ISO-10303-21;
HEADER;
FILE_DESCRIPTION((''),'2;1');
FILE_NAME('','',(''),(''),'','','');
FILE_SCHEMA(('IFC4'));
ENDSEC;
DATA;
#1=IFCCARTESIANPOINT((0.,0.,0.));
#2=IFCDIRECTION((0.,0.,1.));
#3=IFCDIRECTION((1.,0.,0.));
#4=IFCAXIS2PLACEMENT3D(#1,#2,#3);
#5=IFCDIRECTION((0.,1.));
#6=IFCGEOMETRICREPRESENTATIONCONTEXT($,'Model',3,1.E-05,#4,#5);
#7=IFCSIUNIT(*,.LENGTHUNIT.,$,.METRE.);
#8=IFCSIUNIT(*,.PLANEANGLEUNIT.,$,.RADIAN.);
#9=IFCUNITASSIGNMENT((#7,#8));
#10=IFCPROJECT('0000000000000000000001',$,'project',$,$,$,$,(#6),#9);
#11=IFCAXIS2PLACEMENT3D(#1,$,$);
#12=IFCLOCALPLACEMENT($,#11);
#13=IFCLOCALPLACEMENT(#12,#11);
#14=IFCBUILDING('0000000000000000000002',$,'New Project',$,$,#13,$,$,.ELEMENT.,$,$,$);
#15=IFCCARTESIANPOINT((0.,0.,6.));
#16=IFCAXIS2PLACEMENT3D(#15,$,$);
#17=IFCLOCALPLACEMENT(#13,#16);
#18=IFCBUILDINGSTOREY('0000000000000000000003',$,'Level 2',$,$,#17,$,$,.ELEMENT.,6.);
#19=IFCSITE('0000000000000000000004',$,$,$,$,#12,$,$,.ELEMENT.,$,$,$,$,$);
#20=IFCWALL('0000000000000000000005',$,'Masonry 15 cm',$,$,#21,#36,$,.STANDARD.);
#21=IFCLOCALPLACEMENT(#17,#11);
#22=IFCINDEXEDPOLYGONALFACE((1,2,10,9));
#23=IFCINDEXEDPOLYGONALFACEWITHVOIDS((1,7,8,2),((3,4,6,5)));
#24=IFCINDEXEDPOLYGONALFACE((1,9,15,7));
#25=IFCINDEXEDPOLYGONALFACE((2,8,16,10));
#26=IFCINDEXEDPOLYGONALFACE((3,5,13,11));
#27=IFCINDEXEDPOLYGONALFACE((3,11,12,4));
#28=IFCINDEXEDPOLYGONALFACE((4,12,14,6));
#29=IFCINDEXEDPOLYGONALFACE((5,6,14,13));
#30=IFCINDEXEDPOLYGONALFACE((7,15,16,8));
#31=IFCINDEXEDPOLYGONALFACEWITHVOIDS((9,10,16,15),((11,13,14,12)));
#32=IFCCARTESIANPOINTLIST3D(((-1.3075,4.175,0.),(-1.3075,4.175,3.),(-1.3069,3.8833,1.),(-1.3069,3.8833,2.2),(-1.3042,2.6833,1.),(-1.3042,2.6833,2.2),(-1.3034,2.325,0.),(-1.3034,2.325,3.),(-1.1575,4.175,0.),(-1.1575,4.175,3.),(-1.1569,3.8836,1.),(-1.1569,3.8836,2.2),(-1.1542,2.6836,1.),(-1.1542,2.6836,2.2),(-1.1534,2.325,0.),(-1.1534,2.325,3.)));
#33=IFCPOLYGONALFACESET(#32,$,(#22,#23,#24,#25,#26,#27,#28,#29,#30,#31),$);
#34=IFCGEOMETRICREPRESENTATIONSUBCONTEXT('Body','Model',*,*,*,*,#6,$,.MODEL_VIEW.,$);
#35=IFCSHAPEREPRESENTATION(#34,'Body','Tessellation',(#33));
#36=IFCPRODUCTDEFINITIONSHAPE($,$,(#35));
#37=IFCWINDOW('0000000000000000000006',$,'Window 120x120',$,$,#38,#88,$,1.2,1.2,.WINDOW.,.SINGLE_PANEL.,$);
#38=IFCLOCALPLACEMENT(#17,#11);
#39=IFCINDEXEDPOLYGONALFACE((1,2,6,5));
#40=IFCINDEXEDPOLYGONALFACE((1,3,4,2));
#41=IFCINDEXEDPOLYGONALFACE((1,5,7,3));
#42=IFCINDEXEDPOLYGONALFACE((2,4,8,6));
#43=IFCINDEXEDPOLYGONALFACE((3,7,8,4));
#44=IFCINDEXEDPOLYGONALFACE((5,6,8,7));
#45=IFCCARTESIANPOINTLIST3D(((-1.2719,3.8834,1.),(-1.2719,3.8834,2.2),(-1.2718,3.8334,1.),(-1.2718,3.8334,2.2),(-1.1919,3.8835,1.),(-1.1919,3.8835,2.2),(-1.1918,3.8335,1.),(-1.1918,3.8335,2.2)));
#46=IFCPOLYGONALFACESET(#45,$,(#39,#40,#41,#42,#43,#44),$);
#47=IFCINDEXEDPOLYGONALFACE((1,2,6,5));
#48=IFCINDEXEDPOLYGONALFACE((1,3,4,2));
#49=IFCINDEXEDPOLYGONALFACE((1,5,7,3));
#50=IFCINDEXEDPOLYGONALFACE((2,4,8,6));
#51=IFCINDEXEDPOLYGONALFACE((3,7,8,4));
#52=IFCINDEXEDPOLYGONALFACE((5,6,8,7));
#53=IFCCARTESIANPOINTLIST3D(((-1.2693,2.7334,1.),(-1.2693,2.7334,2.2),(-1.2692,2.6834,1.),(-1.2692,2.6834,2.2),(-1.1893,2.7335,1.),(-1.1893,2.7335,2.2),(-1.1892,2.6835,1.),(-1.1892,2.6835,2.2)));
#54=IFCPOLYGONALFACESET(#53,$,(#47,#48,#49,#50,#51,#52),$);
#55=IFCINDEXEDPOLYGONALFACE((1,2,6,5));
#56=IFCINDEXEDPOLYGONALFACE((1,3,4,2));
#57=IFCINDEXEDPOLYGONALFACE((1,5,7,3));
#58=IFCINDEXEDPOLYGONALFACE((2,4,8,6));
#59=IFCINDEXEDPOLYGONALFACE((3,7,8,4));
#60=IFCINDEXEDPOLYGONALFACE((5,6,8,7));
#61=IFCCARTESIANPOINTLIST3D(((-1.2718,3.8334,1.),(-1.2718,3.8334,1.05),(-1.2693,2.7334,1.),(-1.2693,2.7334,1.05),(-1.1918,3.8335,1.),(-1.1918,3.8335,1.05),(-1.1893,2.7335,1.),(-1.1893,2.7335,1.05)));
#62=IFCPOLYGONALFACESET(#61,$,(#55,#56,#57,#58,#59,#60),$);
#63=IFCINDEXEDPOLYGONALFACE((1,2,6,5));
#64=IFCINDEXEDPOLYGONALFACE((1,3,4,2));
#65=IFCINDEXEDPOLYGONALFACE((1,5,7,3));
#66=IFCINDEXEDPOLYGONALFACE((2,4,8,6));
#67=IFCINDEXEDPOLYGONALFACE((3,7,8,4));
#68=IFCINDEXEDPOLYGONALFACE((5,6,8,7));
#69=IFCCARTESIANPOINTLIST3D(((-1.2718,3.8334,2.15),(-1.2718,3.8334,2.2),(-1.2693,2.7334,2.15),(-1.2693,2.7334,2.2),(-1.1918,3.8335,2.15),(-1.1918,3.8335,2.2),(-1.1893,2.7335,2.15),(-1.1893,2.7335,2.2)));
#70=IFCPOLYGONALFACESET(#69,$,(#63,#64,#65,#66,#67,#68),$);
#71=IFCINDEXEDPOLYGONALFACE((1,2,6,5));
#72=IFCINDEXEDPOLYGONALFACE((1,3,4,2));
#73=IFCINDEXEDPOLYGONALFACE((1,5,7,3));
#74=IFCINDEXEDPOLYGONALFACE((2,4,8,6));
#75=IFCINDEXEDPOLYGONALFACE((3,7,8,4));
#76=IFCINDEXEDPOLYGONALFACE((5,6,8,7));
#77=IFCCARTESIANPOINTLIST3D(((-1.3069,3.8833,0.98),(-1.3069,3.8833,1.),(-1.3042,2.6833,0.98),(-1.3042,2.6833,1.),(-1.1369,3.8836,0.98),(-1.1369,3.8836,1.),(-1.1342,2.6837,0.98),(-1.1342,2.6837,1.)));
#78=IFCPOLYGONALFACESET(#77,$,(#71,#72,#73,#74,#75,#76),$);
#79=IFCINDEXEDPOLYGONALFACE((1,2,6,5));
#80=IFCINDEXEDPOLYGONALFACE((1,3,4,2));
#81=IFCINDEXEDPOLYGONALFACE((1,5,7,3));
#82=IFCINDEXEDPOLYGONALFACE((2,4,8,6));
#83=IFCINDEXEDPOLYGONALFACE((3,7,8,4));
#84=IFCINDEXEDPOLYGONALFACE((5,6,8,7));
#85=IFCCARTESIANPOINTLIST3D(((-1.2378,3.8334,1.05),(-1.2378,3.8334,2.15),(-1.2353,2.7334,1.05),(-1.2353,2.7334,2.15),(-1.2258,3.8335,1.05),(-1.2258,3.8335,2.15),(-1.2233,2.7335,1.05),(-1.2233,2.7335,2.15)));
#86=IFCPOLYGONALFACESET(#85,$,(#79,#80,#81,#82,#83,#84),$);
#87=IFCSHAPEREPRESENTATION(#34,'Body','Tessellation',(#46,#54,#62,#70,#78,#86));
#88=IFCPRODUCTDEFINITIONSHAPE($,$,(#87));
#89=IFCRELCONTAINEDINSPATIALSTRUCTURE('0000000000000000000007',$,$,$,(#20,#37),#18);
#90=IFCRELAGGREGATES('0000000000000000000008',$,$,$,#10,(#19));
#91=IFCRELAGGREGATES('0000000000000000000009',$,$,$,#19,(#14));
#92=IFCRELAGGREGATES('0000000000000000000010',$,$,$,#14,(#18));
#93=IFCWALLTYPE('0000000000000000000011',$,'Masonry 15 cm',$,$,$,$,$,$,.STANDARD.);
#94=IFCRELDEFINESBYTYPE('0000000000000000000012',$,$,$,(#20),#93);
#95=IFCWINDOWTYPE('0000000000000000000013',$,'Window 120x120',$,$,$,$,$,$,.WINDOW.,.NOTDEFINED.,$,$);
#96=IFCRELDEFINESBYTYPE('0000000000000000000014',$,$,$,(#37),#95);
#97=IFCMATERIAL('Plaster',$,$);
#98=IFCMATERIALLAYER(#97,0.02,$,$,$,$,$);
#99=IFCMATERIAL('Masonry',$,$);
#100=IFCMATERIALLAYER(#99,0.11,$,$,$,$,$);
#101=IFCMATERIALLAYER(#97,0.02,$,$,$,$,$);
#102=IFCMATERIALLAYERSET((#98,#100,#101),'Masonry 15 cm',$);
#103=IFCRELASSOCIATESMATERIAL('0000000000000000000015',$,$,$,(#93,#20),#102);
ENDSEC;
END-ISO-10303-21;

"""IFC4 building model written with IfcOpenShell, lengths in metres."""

from ifc_helpers import new_model, si_unit, direction, frame, frame_2d, origin, origin_with_axes, place, context, subcontext, project, spatial, polyline, rectangle, outline, extrude, material, layer, layer_set, layer_usage, type_object, element, fill, save


model = new_model("IFC4")

# Units and contexts
model_context = context("Model", 3, precision=1e-05, world=origin_with_axes(), true_north=direction((0.0, 1.0)))
body_context = subcontext(model_context, "Body", "Model", "MODEL_VIEW")
ifc_project = project(units=[si_unit("LENGTHUNIT", "METRE"), si_unit("PLANEANGLEUNIT", "RADIAN")], contexts=[model_context])

# Site, building, storey
site_placement = place(None, origin())
site = spatial("IfcSite", under=ifc_project, at=site_placement, CompositionType="ELEMENT")
building_placement = place(site_placement, origin())
building = spatial("IfcBuilding", under=site, at=building_placement, Name="New Project", CompositionType="ELEMENT")
storey_placement = place(building_placement, frame((0.0, 0.0, 6.0)))
storey = spatial("IfcBuildingStorey", under=building, at=storey_placement, Name="Level 2", CompositionType="ELEMENT", Elevation=6.0)

# Shared definitions
ifc_material_1 = material(Name="Plaster")
ifc_layer_1 = layer(ifc_material_1, 0.02)
ifc_material_2 = material(Name="Masonry")
ifc_layer_2 = layer(ifc_material_2, 0.11)
ifc_layer_3 = layer(ifc_material_1, 0.02)
ifc_layer_set_1 = layer_set([ifc_layer_1, ifc_layer_2, ifc_layer_3], Name="Masonry 15 cm")
ifc_layer_usage_1 = layer_usage(ifc_layer_set_1, "AXIS2", "NEGATIVE", 0.075)
wall_type = type_object("IfcWallType", Name="Masonry 15 cm", PredefinedType="STANDARD", material=ifc_layer_set_1)
window_type = type_object("IfcWindowType", Name="Window 120x120", PartitioningType="NOTDEFINED", PredefinedType="WINDOW")

# Wall, opening, window
wall_1_placement = place(storey_placement, frame((-1.2325, 4.175, 0.0), z_axis=(0.0, 0.0, 1.0), x_axis=(0.002207, -0.999998, 0.0)))
wall_1 = element("IfcWall", 1, at=wall_1_placement, inside=storey, type_object=wall_type, material=ifc_layer_usage_1, Name="Masonry 15 cm", PredefinedType="STANDARD", context=body_context, shape_type="SweptSolid", body=[
    extrude(outline(polyline([(-0.0002, -0.075), (1.8498, -0.075), (1.8502, 0.075), (0.0002, 0.075), (-0.0002, -0.075)])), origin(), (0.0, 0.0, 1.0), 3.0),
])
opening_1_placement = place(wall_1_placement, frame((0.2916, 0.0, 1.0)))
opening_1 = element("IfcOpeningElement", 2, at=opening_1_placement, cuts=wall_1, PredefinedType="OPENING", context=body_context, shape_type="SweptSolid", body=[
    extrude(rectangle(XDim=1.2, YDim=0.25, at=frame_2d((0.6, 0.0))), origin(), (0.0, 0.0, 1.0), 1.2),
])
window_1_placement = place(opening_1_placement, origin())
window_1 = element("IfcWindow", 3, at=window_1_placement, inside=storey, type_object=window_type, Name="Window 120x120", OverallHeight=1.2, OverallWidth=1.2, PartitioningType="SINGLE_PANEL", PredefinedType="WINDOW", context=body_context, shape_type="SweptSolid", body=[
    extrude(outline(polyline([(0.0, -0.04), (0.05, -0.04), (0.05, 0.04), (0.0, 0.04), (0.0, -0.04)])), origin(), (0.0, 0.0, 1.0), 1.2),
    extrude(outline(polyline([(1.15, -0.04), (1.2, -0.04), (1.2, 0.04), (1.15, 0.04), (1.15, -0.04)])), origin(), (0.0, 0.0, 1.0), 1.2),
    extrude(outline(polyline([(0.05, -0.04), (1.15, -0.04), (1.15, 0.04), (0.05, 0.04), (0.05, -0.04)])), origin(), (0.0, 0.0, 1.0), 0.05),
    extrude(outline(polyline([(0.05, -0.04), (1.15, -0.04), (1.15, 0.04), (0.05, 0.04), (0.05, -0.04)])), frame((0.0, 0.0, 1.15)), (0.0, 0.0, 1.0), 0.05),
    extrude(outline(polyline([(0.0, -0.075), (1.2, -0.075), (1.2, 0.095), (0.0, 0.095), (0.0, -0.075)])), frame((0.0, 0.0, -0.02)), (0.0, 0.0, 1.0), 0.02),
    extrude(outline(polyline([(0.05, -0.006), (1.15, -0.006), (1.15, 0.006), (0.05, 0.006), (0.05, -0.006)])), frame((0.0, 0.0, 0.05)), (0.0, 0.0, 1.0), 1.1),
])
fill(opening_1, window_1)

save(model, "model.ifc")
